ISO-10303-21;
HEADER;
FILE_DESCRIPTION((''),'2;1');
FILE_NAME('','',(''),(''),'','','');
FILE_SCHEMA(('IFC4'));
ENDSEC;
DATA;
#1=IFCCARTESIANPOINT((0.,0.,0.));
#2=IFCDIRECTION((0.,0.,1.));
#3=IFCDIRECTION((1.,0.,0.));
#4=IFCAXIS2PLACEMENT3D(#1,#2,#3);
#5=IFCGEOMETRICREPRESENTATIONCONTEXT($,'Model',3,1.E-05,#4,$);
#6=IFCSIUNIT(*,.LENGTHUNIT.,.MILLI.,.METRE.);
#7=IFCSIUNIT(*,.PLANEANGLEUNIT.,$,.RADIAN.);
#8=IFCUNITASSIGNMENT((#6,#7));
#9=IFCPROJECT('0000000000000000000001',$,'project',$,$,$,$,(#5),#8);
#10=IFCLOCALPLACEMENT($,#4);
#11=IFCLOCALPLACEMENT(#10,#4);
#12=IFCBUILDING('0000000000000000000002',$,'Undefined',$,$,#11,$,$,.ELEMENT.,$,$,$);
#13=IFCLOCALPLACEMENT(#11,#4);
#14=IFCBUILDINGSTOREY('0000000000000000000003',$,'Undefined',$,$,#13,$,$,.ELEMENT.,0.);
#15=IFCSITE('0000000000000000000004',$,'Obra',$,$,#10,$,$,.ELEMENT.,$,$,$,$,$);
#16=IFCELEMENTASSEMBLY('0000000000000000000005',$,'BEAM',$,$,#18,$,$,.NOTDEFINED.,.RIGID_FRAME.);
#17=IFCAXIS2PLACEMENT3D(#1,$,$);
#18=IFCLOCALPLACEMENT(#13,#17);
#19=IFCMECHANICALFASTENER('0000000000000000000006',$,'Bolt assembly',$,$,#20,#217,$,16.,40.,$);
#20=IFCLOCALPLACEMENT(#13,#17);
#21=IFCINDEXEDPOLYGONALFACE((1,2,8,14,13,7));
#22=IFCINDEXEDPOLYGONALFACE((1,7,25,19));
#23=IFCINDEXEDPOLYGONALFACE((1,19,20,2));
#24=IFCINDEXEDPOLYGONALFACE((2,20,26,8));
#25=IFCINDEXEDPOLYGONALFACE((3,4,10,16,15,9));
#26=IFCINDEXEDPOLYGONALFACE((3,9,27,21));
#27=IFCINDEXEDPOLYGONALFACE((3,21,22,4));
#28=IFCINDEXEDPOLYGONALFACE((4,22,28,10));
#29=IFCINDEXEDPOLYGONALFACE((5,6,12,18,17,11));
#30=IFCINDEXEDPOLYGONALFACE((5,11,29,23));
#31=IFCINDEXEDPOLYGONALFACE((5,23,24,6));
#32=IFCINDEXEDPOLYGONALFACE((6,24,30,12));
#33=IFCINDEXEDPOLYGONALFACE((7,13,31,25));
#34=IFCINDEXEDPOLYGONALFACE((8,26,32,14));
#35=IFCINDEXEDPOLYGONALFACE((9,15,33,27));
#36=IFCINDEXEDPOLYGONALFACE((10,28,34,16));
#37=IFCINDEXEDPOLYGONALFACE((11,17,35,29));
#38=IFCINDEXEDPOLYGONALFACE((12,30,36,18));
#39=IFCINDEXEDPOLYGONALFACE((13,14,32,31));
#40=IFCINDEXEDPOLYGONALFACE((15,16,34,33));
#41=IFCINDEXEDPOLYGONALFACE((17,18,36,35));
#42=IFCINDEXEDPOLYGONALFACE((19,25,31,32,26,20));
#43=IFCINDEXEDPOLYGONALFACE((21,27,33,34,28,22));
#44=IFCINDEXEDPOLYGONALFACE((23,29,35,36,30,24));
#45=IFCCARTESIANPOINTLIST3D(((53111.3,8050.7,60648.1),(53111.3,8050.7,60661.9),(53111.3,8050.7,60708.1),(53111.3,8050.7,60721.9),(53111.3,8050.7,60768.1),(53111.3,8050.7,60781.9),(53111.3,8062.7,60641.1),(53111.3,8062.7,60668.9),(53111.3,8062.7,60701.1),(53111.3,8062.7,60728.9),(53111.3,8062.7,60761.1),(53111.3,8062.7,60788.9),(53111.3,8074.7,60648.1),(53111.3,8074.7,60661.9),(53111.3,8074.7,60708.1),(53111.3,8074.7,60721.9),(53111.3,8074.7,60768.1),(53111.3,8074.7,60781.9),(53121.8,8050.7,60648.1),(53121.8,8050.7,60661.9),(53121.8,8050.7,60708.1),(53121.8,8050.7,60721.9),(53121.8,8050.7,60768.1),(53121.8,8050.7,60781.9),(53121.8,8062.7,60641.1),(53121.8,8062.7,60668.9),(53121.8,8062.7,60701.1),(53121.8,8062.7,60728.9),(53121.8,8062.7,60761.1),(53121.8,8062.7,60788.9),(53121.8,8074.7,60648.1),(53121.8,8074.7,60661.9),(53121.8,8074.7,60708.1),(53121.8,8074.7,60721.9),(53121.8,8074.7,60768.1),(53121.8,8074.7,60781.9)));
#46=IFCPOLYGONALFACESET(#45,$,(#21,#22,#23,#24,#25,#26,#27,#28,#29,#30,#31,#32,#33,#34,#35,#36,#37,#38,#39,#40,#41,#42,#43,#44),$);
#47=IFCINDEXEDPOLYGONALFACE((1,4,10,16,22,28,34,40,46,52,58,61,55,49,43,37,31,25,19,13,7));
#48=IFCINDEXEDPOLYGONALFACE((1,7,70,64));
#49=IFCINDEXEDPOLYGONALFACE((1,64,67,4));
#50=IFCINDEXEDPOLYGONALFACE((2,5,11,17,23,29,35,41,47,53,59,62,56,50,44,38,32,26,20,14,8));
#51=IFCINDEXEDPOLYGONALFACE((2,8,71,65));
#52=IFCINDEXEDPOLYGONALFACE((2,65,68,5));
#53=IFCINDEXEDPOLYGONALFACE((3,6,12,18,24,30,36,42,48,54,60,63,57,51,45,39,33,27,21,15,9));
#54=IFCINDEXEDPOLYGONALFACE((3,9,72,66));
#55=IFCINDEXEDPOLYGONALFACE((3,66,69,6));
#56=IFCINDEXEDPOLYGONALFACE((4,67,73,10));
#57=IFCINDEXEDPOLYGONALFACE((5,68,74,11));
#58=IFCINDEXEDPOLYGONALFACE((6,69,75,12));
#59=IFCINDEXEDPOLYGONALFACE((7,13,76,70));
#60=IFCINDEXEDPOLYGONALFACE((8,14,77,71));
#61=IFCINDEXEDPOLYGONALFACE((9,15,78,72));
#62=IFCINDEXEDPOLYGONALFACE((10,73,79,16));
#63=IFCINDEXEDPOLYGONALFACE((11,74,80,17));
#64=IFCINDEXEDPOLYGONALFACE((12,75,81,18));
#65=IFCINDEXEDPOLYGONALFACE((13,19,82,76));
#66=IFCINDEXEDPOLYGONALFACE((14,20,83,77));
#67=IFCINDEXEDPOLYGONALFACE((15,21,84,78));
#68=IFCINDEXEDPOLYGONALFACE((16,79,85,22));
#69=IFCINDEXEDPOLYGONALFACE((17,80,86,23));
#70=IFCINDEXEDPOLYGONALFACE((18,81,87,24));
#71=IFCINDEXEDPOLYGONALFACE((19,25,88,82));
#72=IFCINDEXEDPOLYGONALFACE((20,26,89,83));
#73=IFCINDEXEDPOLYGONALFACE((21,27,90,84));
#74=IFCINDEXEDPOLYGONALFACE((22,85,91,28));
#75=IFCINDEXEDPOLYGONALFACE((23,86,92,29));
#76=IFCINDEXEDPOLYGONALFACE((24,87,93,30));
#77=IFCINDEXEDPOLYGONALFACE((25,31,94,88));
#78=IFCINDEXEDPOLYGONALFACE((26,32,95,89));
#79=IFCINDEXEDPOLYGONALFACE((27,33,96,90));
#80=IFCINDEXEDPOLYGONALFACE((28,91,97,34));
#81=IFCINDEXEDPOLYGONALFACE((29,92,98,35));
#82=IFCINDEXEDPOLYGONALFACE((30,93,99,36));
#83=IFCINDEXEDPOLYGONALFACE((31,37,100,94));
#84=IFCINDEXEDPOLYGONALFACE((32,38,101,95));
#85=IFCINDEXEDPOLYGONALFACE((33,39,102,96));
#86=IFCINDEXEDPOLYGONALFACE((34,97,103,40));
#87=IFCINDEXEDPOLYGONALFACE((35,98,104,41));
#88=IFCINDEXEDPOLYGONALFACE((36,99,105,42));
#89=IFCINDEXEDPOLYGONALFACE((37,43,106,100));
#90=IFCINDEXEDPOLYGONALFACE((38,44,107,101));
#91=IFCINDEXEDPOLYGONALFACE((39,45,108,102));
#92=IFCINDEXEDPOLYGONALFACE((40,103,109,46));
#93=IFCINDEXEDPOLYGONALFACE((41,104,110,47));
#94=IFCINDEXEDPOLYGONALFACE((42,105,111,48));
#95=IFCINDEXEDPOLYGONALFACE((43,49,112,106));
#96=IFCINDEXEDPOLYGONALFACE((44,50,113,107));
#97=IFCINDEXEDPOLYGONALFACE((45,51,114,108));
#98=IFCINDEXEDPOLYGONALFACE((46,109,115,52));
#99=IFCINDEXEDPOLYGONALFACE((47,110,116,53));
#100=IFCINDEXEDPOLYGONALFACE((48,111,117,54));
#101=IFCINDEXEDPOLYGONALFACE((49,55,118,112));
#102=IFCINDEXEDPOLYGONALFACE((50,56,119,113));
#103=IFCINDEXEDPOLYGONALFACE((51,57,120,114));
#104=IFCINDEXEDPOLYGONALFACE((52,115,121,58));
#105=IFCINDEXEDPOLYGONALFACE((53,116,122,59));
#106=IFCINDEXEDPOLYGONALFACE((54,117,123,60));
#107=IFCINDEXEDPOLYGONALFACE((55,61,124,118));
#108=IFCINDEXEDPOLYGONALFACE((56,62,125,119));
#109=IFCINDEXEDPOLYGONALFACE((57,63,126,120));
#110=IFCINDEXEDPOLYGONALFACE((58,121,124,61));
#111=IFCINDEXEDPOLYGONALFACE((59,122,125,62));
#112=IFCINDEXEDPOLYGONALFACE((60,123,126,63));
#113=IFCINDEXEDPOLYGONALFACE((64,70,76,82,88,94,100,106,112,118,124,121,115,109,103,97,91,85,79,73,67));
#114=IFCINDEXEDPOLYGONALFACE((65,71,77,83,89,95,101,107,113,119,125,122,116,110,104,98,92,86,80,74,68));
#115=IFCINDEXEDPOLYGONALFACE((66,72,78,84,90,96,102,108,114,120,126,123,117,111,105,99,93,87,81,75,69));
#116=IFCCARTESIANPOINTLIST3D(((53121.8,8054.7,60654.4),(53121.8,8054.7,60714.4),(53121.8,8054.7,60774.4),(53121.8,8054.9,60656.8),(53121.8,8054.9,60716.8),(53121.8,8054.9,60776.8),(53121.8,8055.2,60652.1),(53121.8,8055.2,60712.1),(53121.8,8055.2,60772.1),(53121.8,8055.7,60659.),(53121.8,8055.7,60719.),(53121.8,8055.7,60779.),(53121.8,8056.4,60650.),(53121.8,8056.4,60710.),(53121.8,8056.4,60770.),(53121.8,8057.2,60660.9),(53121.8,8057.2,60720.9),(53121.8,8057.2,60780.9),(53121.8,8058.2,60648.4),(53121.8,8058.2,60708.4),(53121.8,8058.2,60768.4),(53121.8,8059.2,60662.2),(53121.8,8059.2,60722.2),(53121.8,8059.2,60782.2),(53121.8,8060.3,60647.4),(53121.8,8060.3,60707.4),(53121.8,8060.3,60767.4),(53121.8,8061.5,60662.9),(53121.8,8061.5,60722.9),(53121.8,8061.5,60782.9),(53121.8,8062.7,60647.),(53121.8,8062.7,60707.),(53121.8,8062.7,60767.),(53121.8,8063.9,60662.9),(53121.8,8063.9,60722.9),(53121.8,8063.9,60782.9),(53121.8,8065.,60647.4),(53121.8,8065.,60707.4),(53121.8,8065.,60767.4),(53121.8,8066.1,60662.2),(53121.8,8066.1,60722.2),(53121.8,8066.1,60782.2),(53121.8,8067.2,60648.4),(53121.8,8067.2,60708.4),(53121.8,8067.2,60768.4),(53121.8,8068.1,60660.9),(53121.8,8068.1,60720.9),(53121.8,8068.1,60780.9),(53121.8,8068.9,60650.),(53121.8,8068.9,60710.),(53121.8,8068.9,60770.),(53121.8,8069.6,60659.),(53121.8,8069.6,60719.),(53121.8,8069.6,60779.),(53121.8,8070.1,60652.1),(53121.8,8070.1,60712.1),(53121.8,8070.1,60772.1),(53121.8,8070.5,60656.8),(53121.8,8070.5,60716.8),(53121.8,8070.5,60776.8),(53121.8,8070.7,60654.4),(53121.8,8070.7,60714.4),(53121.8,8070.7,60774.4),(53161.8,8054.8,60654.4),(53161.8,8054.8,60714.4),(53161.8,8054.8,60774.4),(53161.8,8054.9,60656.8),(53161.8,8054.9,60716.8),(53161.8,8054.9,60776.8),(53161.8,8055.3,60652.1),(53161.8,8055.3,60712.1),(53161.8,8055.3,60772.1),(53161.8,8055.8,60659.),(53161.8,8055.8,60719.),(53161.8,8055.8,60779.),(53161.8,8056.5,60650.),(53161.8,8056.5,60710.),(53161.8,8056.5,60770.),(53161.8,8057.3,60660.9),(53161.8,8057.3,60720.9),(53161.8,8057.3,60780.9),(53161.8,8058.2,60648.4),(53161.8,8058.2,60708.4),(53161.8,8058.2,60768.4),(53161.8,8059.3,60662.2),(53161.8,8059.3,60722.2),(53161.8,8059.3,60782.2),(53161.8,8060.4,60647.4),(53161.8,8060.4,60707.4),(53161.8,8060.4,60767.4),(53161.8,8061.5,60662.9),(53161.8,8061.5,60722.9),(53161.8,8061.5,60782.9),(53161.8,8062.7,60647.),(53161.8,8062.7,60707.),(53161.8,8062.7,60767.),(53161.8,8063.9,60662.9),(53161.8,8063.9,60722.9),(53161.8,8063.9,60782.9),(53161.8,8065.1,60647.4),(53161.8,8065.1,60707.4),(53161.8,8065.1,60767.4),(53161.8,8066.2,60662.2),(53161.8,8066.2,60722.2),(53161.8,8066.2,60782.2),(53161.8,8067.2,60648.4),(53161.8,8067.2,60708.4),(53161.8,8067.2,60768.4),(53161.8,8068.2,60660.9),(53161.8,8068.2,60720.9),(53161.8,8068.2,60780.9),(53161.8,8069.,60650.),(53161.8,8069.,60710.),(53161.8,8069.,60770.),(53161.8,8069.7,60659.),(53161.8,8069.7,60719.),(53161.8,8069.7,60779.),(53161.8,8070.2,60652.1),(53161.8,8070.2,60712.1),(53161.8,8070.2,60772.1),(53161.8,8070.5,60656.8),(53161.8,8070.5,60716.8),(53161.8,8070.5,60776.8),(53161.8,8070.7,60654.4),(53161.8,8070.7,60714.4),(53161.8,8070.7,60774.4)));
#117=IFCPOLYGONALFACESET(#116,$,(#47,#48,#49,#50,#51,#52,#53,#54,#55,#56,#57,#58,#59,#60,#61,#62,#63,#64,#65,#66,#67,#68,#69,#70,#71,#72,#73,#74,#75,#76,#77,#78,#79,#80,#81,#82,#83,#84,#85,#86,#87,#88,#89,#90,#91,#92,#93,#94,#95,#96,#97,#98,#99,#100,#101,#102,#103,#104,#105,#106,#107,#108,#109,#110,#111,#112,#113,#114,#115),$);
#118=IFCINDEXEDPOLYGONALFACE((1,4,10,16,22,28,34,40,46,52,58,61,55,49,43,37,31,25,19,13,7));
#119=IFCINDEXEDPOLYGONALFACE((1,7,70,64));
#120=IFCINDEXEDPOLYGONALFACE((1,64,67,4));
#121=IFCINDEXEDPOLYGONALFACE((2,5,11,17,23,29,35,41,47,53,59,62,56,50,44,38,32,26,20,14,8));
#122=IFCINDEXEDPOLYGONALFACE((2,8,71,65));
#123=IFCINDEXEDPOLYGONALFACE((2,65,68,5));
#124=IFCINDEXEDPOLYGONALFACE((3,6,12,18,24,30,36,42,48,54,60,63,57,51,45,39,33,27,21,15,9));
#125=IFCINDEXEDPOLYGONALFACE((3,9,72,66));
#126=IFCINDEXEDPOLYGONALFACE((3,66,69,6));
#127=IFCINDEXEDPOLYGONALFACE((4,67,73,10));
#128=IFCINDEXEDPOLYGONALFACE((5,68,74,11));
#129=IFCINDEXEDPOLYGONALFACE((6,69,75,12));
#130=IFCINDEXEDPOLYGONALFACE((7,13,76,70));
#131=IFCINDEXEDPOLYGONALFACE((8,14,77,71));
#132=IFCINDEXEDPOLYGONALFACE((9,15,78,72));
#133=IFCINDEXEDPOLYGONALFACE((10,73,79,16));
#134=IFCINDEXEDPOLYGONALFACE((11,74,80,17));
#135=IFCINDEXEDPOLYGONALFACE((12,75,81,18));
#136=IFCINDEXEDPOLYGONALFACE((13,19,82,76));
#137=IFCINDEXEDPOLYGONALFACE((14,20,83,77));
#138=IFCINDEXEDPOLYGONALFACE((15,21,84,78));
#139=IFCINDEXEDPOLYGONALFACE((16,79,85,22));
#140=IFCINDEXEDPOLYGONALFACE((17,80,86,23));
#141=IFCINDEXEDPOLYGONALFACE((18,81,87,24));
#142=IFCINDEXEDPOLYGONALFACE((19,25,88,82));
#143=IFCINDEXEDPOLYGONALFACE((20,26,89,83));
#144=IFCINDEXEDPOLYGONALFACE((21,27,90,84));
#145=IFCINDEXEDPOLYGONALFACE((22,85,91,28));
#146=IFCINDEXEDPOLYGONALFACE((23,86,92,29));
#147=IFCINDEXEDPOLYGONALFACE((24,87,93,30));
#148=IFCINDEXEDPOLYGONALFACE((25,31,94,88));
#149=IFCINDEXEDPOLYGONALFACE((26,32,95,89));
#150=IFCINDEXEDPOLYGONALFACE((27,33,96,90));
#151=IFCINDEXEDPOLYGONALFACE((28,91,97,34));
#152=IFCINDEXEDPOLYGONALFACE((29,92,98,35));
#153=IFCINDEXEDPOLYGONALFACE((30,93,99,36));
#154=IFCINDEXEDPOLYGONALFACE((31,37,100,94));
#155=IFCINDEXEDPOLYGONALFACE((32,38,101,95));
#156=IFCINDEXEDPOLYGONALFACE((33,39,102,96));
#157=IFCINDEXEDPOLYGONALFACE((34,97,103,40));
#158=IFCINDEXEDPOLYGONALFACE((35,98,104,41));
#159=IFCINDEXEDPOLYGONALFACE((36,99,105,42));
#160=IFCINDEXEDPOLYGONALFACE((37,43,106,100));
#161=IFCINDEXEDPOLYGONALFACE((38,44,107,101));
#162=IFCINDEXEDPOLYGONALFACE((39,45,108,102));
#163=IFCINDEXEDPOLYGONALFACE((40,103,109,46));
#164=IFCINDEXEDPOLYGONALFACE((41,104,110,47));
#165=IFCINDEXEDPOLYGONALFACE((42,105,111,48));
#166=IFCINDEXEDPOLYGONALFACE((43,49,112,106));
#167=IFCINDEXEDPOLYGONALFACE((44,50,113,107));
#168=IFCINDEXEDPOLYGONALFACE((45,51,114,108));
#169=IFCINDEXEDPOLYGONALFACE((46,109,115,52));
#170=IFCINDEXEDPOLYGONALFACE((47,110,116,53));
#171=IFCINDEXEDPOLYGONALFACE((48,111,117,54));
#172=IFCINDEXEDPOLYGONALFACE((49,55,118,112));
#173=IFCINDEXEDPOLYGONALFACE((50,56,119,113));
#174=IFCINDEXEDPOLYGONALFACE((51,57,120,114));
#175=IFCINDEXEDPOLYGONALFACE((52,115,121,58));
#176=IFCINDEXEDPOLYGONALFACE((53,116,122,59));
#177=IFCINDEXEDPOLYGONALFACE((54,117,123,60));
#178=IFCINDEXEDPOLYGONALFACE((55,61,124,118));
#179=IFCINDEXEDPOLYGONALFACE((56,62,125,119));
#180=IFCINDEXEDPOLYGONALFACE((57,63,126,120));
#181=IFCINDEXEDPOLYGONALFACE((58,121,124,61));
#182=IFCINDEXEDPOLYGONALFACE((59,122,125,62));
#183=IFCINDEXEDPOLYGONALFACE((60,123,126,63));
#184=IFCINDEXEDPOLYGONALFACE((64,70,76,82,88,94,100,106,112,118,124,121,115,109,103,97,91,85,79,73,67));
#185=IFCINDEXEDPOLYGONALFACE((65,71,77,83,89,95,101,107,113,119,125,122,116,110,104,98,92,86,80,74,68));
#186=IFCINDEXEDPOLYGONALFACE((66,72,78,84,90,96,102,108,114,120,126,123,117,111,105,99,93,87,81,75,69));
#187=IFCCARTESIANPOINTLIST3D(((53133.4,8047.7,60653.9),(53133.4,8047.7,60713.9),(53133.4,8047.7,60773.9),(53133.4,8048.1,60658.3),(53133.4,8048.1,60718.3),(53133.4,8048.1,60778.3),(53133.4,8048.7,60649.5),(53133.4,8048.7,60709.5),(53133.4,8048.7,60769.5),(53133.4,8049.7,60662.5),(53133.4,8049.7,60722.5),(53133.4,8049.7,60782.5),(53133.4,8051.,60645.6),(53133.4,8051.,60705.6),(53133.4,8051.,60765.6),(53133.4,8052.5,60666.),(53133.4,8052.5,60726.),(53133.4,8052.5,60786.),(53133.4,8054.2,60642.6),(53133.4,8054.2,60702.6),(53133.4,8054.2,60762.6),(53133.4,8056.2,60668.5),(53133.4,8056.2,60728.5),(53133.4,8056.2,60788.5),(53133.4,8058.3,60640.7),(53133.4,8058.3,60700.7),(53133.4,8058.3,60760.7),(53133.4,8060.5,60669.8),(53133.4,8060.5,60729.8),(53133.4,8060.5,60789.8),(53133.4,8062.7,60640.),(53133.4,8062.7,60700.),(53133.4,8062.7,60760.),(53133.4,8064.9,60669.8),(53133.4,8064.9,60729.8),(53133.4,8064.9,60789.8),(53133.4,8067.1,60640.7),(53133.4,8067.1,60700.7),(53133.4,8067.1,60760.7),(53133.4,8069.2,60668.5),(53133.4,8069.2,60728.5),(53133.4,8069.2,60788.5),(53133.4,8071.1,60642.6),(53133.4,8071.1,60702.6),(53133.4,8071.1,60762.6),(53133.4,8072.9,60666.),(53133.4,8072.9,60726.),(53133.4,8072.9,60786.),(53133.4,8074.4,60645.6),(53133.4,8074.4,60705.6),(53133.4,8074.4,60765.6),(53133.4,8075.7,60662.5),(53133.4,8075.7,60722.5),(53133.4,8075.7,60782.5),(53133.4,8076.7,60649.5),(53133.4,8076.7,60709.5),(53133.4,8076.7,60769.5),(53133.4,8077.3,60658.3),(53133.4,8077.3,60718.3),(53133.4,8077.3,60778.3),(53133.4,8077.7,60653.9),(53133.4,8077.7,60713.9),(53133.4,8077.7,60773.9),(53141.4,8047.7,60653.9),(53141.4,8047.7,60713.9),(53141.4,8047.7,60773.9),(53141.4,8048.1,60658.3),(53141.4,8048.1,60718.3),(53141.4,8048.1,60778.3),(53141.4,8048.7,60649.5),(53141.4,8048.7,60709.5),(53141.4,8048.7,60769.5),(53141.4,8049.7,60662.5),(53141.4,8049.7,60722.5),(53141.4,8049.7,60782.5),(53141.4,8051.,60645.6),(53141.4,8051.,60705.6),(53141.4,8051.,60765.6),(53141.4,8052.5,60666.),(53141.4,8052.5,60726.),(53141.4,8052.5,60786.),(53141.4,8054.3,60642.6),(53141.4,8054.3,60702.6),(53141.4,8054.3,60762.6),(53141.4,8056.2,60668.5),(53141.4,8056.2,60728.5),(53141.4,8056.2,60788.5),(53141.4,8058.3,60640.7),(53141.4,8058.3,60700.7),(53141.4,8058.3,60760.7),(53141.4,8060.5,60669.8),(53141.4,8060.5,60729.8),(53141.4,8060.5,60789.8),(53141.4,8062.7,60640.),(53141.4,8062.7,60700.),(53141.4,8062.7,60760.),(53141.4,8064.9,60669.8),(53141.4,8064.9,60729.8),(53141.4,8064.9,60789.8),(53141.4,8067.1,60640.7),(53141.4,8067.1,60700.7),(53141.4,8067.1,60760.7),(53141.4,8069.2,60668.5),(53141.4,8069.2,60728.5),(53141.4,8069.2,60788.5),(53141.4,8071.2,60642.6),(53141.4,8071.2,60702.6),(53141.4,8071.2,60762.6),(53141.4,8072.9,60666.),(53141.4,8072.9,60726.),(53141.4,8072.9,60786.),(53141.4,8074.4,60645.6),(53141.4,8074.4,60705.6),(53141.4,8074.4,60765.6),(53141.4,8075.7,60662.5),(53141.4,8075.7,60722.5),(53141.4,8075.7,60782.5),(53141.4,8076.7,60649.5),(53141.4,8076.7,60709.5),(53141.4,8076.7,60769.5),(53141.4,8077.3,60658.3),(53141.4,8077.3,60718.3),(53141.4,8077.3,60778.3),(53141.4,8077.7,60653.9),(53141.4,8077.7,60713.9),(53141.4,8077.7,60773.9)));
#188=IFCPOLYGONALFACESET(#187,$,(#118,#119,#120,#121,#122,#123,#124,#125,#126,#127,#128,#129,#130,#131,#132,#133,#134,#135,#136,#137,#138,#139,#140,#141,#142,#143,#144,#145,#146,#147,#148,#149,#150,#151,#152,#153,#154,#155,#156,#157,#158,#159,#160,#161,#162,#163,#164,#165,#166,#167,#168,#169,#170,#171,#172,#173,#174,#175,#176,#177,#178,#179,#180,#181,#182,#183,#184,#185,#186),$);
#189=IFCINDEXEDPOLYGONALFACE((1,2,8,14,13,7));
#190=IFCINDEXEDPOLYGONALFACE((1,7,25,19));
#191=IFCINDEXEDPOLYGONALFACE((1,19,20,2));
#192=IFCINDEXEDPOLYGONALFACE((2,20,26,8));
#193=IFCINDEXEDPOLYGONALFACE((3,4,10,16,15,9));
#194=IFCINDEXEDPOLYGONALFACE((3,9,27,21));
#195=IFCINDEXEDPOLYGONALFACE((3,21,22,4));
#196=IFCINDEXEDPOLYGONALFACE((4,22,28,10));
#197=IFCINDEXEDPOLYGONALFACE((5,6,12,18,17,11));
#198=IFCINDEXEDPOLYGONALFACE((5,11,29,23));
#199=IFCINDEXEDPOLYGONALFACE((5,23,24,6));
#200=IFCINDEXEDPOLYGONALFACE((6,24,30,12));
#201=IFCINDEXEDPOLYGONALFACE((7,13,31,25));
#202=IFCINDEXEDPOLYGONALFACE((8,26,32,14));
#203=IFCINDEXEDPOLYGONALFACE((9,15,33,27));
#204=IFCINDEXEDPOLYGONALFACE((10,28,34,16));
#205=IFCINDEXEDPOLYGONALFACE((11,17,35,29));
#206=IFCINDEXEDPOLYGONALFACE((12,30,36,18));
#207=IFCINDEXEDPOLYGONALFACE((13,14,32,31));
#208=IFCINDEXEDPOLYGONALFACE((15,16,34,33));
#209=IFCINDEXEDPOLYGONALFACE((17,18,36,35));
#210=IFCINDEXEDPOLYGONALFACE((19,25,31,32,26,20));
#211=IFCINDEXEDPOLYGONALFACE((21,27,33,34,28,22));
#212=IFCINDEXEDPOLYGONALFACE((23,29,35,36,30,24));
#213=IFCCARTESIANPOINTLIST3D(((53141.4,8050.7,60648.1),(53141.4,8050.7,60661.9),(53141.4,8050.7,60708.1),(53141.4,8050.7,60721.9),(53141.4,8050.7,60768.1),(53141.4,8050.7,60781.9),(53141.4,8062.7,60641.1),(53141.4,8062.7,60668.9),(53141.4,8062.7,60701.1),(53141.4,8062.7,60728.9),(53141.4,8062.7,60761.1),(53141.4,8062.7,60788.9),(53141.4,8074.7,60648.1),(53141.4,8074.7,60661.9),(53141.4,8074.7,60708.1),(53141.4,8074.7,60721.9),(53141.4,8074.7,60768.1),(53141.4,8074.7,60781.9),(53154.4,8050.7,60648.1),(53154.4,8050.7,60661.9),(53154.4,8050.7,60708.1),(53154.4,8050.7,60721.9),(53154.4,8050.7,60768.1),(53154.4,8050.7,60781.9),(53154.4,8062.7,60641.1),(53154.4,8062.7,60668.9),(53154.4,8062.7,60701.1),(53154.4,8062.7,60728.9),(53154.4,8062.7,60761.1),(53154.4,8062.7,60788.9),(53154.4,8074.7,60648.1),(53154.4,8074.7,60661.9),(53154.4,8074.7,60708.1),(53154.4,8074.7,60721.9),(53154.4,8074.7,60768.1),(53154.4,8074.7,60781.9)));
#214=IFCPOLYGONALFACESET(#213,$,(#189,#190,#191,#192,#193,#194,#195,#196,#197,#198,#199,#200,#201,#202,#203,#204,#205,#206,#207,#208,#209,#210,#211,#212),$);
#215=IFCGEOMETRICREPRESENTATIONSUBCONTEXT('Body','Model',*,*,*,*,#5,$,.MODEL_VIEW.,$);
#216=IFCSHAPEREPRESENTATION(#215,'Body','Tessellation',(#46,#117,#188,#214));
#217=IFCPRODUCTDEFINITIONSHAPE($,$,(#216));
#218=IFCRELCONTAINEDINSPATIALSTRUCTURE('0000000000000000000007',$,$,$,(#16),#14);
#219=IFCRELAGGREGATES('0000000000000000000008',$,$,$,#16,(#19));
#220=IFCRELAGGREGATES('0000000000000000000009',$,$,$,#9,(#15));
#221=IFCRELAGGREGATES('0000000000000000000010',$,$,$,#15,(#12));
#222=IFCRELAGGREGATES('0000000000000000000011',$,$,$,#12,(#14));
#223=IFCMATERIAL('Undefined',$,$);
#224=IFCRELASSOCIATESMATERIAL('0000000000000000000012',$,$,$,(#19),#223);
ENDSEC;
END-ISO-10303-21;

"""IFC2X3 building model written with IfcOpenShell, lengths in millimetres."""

from ifc_helpers import new_model, si_unit, frame, origin_with_axes, origin_2d_with_axis, place, context, subcontext, project, spatial, polyline, circle, outline, extrude, source, transform, mapped, material, element, aggregate, save


model = new_model("IFC2X3")

# Units and contexts
model_context = context("Model", 3, precision=1e-05, world=origin_with_axes())
body_context = subcontext(model_context, "Body", "Model", "MODEL_VIEW")
ifc_project = project(units=[si_unit("LENGTHUNIT", "METRE", prefix="MILLI"), si_unit("PLANEANGLEUNIT", "RADIAN")], contexts=[model_context])

# Site, building, storey
site_placement = place(None, origin_with_axes())
site = spatial("IfcSite", under=ifc_project, at=site_placement, Name="Obra", CompositionType="ELEMENT")
building_placement = place(site_placement, origin_with_axes())
building = spatial("IfcBuilding", under=site, at=building_placement, Name="Undefined", CompositionType="ELEMENT")
storey_placement = place(building_placement, origin_with_axes())
storey = spatial("IfcBuildingStorey", under=building, at=storey_placement, Name="Undefined", CompositionType="ELEMENT", Elevation=0.0)

# Element assembly, mechanical fastener
ifc_material_1 = material(Name="Undefined")
assembly_1_placement = place(storey_placement, origin_with_axes())
assembly_1 = element("IfcElementAssembly", 1, at=assembly_1_placement, inside=storey, Name="BEAM", AssemblyPlace="NOTDEFINED", PredefinedType="RIGID_FRAME")
shared_shape_1 = source(origin_with_axes(), body_context, "Body", "SweptSolid", [
    extrude(outline(polyline([(13.9, 0.0), (6.9, 12.0), (-6.9, 12.0), (-13.9, 0.0), (-6.9, -12.0), (6.9, -12.0), (13.9, 0.0)])), frame((0.0, -19.7, 0.0), z_axis=(0.0, 1.0, 0.0), x_axis=(1.0, 0.0, 0.0)), (0.0, 0.0, 1.0), 10.6),
    extrude(circle(Radius=8.0, at=origin_2d_with_axis()), frame((0.0, -9.1, 0.0), z_axis=(0.0, 1.0, 0.0), x_axis=(1.0, 0.0, 0.0)), (0.0, 0.0, 1.0), 40.0),
    extrude(circle(Radius=15.0, at=origin_2d_with_axis()), frame((0.0, 2.5, 0.0), z_axis=(0.0, 1.0, 0.0), x_axis=(1.0, 0.0, 0.0)), (0.0, 0.0, 1.0), 8.0),
    extrude(outline(polyline([(13.9, 0.0), (6.9, 12.0), (-6.9, 12.0), (-13.9, 0.0), (-6.9, -12.0), (6.9, -12.0), (13.9, 0.0)])), frame((0.0, 10.5, 0.0), z_axis=(0.0, 1.0, 0.0), x_axis=(1.0, 0.0, 0.0)), (0.0, 0.0, 1.0), 13.0),
])
mechanical_fastener_1_placement = place(assembly_1_placement, frame((53130.9, 8112.7, 60835.0), z_axis=(0.001508, -0.999999, 0.0), x_axis=(0.0, 0.0, -1.0)))
mechanical_fastener_1 = element("IfcMechanicalFastener", 2, at=mechanical_fastener_1_placement, material=ifc_material_1, Name="Bolt assembly", NominalDiameter=16.0, NominalLength=40.0, context=body_context, shape_type="MappedRepresentation", body=[
    mapped(shared_shape_1, transform((60.0, 0.0, 50.0))),
    mapped(shared_shape_1, transform((120.0, 0.0, 50.0))),
    mapped(shared_shape_1, transform((180.0, 0.0, 50.0))),
])

aggregate(assembly_1, [mechanical_fastener_1])

save(model, "model.ifc")
